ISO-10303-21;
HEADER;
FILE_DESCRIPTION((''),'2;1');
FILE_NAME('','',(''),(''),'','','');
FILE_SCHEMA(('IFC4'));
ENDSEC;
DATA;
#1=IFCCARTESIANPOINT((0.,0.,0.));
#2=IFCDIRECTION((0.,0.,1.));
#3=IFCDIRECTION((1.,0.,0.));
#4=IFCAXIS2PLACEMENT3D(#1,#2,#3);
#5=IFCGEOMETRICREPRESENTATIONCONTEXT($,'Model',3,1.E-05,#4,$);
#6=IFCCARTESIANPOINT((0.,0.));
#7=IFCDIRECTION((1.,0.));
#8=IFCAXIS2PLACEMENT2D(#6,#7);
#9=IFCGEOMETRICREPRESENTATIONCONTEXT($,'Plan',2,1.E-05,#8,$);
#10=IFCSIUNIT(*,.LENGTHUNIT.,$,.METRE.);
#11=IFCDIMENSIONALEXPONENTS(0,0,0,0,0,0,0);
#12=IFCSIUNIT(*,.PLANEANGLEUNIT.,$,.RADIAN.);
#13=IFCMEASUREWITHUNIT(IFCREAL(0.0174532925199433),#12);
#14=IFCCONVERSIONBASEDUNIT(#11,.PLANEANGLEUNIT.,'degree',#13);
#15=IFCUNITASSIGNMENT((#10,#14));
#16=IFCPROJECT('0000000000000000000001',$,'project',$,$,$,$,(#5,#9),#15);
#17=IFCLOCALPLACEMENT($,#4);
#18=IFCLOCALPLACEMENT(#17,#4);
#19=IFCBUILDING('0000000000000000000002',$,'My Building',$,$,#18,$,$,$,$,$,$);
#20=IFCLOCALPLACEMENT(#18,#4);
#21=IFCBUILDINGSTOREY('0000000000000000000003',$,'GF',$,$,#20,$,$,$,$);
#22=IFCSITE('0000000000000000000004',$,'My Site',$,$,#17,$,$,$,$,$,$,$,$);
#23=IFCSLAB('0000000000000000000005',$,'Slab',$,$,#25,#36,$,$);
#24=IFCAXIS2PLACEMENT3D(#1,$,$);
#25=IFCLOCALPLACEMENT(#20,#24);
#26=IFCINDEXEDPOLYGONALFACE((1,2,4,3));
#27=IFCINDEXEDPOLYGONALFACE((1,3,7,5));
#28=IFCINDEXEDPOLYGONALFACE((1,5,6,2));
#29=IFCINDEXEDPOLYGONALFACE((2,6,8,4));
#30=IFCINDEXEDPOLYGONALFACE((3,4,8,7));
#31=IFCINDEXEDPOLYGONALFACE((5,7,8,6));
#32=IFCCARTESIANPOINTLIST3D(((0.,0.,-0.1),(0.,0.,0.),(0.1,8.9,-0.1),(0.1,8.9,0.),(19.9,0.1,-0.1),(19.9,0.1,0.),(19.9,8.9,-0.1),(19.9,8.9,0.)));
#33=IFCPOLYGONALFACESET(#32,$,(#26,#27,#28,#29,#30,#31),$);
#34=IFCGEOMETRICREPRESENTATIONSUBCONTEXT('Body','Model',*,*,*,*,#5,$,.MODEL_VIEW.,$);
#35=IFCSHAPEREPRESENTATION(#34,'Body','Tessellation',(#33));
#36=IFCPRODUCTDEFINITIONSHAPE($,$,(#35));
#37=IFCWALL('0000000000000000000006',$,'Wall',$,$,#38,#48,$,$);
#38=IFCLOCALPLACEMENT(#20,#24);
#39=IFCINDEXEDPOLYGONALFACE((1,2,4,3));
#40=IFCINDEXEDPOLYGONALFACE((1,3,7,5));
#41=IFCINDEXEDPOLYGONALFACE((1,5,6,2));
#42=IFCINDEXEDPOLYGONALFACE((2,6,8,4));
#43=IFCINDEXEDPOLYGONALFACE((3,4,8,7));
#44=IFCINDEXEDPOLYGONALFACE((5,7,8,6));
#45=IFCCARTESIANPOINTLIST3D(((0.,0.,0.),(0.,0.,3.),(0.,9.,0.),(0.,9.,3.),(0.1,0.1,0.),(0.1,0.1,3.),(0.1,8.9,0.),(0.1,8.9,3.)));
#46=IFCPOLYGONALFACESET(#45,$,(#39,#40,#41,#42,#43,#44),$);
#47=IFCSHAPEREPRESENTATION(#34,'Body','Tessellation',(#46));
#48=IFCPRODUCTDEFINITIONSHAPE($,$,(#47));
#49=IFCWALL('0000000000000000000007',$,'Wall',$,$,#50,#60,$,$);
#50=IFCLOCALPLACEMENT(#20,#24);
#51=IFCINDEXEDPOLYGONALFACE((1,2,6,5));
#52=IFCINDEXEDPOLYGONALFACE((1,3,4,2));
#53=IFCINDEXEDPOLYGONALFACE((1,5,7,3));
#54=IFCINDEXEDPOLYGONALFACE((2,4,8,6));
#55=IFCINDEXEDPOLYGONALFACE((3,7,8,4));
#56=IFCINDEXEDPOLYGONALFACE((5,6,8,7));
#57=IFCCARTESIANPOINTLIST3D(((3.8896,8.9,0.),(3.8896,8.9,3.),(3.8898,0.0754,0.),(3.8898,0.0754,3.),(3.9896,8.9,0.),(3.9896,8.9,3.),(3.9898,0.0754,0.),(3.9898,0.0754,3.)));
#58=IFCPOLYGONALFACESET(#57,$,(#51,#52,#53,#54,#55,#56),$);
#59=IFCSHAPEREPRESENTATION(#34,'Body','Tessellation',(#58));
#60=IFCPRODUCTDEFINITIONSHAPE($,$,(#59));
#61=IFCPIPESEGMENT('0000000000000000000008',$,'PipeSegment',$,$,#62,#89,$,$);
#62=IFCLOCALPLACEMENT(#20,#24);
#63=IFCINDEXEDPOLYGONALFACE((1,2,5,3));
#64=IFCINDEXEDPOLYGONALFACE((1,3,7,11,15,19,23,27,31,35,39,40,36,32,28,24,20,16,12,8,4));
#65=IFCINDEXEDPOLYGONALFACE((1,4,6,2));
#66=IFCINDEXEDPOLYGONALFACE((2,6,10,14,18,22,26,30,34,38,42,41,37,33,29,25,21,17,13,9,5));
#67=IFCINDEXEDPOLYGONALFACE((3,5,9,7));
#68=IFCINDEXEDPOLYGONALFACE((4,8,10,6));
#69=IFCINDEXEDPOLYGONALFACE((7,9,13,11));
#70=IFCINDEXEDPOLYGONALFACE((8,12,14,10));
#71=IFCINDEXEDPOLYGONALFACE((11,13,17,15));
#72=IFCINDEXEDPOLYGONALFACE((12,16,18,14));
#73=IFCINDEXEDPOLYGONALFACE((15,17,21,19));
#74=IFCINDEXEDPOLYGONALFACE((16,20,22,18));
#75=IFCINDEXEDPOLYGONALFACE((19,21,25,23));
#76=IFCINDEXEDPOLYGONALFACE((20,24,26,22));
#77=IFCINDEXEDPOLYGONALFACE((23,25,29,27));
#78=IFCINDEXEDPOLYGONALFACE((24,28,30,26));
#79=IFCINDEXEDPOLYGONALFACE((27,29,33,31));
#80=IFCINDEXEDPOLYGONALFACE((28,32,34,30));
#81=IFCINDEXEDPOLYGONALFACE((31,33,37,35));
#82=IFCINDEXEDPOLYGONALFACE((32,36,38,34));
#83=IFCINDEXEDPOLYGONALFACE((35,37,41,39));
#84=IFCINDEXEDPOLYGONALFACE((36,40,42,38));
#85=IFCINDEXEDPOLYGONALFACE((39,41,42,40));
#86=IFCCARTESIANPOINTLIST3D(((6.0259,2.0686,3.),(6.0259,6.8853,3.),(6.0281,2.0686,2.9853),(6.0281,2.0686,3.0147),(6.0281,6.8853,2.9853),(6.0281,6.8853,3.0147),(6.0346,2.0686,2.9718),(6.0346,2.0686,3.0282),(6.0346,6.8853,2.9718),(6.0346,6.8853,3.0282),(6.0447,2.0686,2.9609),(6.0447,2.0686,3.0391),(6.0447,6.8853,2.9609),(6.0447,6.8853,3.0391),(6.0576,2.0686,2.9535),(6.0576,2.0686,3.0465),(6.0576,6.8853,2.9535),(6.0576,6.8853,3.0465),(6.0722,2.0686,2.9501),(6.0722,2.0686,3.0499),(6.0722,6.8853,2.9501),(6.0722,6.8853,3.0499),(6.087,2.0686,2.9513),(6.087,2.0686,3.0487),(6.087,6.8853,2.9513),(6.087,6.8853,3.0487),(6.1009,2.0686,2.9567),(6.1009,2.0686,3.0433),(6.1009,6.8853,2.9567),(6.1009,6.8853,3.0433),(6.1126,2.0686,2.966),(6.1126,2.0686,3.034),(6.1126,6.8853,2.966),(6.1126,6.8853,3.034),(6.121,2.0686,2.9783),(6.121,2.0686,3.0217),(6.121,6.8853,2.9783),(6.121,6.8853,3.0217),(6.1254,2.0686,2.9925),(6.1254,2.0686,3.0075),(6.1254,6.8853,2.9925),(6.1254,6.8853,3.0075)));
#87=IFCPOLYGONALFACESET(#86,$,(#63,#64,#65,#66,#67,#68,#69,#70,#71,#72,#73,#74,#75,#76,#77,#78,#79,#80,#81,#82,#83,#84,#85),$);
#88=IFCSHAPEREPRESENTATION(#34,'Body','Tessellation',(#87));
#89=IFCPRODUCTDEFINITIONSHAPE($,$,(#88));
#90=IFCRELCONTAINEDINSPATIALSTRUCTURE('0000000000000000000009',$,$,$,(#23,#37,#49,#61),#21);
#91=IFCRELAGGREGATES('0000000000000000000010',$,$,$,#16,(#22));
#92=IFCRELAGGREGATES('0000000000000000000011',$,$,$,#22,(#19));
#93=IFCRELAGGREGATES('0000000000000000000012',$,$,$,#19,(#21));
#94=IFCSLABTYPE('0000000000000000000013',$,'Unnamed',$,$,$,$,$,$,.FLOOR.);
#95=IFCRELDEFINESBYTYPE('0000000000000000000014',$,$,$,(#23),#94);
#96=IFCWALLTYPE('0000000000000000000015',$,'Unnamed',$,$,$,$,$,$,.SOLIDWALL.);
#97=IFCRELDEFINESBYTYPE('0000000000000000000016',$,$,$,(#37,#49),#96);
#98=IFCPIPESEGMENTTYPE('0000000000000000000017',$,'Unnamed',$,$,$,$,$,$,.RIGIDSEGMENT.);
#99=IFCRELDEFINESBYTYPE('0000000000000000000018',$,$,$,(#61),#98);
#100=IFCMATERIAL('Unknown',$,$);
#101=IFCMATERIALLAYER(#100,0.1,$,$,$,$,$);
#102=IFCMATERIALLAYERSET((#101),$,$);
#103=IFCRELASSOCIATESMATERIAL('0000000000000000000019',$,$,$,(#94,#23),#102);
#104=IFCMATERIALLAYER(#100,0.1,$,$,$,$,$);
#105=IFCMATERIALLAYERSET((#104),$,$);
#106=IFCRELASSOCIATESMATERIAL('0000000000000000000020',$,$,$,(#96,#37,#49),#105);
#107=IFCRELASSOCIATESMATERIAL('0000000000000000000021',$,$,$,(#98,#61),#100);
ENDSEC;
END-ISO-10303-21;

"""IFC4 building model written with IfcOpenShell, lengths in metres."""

from ifc_helpers import new_model, entity, si_unit, converted_unit, frame, origin_with_axes, origin_2d_with_axis, place, context, subcontext, project, spatial, line, indexed_curve, circle, outline, extrude, material, layer, layer_set, layer_usage, material_profile, profile_set, profile_usage, type_object, element, save


model = new_model("IFC4")

# Units and contexts
model_context = context("Model", 3, precision=1e-05, world=origin_with_axes())
plan_context = context("Plan", 2, precision=1e-05, world=origin_2d_with_axis())
body_context_1 = subcontext(model_context, "Body", "Model", "MODEL_VIEW")
ifc_project = project(units=[si_unit("LENGTHUNIT", "METRE"), converted_unit("PLANEANGLEUNIT", "degree", entity("IfcReal", 0.0174532925199433), si_unit("PLANEANGLEUNIT", "RADIAN"), dimensions=[0, 0, 0, 0, 0, 0, 0])], contexts=[model_context, plan_context])

# Site, building, storey
site_placement = place(None, origin_with_axes())
site = spatial("IfcSite", under=ifc_project, at=site_placement, Name="My Site")
building_placement = place(site_placement, origin_with_axes())
building = spatial("IfcBuilding", under=site, at=building_placement, Name="My Building")
storey_placement = place(building_placement, origin_with_axes())
storey = spatial("IfcBuildingStorey", under=building, at=storey_placement, Name="GF")

# Slab
ifc_material = material(Name="Unknown")
ifc_layer_1 = layer(ifc_material, 0.1)
ifc_layer_set_1 = layer_set([ifc_layer_1])
ifc_layer_usage_1 = layer_usage(ifc_layer_set_1, "AXIS3", "POSITIVE", -0.1)
slab_type = type_object("IfcSlabType", Name="Unnamed", PredefinedType="FLOOR", material=ifc_layer_set_1)
slab_placement = place(storey_placement, frame((0.1, 8.9, 0.0), z_axis=(0.0, 0.0, 1.0), x_axis=(1.0, 0.0, 0.0)))
element("IfcSlab", 1, at=slab_placement, inside=storey, type_object=slab_type, material=ifc_layer_usage_1, Name="Slab", context=body_context_1, shape_type="SweptSolid", body=[
    extrude(outline(indexed_curve([(0.0, 0.0), (19.8, 0.0), (19.8, -8.8), (-0.1, -8.9), (0.0, 0.0)])), frame((0.0, 0.0, -0.1), z_axis=(0.0, 0.0, 1.0), x_axis=(1.0, 0.0, 0.0)), (0.0, 0.0, 1.0), 0.1),
])

# Shared definitions
ifc_layer_2 = layer(ifc_material, 0.1)
ifc_layer_set_2 = layer_set([ifc_layer_2])
wall_type = type_object("IfcWallType", Name="Unnamed", PredefinedType="SOLIDWALL", material=ifc_layer_set_2)

# Walls
ifc_layer_usage_2 = layer_usage(ifc_layer_set_2, "AXIS2", "POSITIVE", 0.0)
wall_1_placement = place(storey_placement, frame((0.0, 9.0, 0.0), z_axis=(0.0, 0.0, 1.0), x_axis=(0.0, -1.0, 0.0)))
element("IfcWall", 2, at=wall_1_placement, inside=storey, type_object=wall_type, material=ifc_layer_usage_2, Name="Wall", context=body_context_1, shape_type="SweptSolid", body=[
    extrude(outline(indexed_curve([(0.0, 0.0), (0.1, 0.1), (8.9, 0.1), (9.0, 0.0)], segments=[line(1, 2, 3, 4, 1)])), origin_with_axes(), (0.0, 0.0, 1.0), 3.0),
])
ifc_layer_usage_3 = layer_usage(ifc_layer_set_2, "AXIS2", "POSITIVE", 0.0)
wall_2_placement = place(storey_placement, frame((3.9898, 0.0754, 0.0), z_axis=(0.0, 0.0, 1.0), x_axis=(-0.000021, 1.0, 0.0)))
element("IfcWall", 3, at=wall_2_placement, inside=storey, type_object=wall_type, material=ifc_layer_usage_3, Name="Wall", context=body_context_1, shape_type="SweptSolid", body=[
    extrude(outline(indexed_curve([(0.0, 0.0), (0.0, 0.1), (8.8246, 0.1), (8.8246, 0.0)], segments=[line(1, 2, 3, 4, 1)])), origin_with_axes(), (0.0, 0.0, 1.0), 3.0),
])

# Pipe segment
ifc_material_profile = material_profile(ifc_material, circle(Radius=0.05))
ifc_profile_set = profile_set([ifc_material_profile])
ifc_profile_usage = profile_usage(ifc_profile_set, cardinal=5)
pipe_segment_type = type_object("IfcPipeSegmentType", Name="Unnamed", PredefinedType="RIGIDSEGMENT", material=ifc_profile_set)
pipe_segment_placement = place(storey_placement, frame((6.0759, 6.8853, 3.0), z_axis=(0.0, -1.0, 0.0), x_axis=(-1.0, 0.0, 0.0)))
element("IfcPipeSegment", 4, at=pipe_segment_placement, inside=storey, type_object=pipe_segment_type, material=ifc_profile_usage, Name="PipeSegment", context=body_context_1, shape_type="SweptSolid", body=[
    extrude(circle(Radius=0.05), origin_with_axes(), (0.0, 0.0, 1.0), 4.8167),
])

save(model, "model.ifc")
